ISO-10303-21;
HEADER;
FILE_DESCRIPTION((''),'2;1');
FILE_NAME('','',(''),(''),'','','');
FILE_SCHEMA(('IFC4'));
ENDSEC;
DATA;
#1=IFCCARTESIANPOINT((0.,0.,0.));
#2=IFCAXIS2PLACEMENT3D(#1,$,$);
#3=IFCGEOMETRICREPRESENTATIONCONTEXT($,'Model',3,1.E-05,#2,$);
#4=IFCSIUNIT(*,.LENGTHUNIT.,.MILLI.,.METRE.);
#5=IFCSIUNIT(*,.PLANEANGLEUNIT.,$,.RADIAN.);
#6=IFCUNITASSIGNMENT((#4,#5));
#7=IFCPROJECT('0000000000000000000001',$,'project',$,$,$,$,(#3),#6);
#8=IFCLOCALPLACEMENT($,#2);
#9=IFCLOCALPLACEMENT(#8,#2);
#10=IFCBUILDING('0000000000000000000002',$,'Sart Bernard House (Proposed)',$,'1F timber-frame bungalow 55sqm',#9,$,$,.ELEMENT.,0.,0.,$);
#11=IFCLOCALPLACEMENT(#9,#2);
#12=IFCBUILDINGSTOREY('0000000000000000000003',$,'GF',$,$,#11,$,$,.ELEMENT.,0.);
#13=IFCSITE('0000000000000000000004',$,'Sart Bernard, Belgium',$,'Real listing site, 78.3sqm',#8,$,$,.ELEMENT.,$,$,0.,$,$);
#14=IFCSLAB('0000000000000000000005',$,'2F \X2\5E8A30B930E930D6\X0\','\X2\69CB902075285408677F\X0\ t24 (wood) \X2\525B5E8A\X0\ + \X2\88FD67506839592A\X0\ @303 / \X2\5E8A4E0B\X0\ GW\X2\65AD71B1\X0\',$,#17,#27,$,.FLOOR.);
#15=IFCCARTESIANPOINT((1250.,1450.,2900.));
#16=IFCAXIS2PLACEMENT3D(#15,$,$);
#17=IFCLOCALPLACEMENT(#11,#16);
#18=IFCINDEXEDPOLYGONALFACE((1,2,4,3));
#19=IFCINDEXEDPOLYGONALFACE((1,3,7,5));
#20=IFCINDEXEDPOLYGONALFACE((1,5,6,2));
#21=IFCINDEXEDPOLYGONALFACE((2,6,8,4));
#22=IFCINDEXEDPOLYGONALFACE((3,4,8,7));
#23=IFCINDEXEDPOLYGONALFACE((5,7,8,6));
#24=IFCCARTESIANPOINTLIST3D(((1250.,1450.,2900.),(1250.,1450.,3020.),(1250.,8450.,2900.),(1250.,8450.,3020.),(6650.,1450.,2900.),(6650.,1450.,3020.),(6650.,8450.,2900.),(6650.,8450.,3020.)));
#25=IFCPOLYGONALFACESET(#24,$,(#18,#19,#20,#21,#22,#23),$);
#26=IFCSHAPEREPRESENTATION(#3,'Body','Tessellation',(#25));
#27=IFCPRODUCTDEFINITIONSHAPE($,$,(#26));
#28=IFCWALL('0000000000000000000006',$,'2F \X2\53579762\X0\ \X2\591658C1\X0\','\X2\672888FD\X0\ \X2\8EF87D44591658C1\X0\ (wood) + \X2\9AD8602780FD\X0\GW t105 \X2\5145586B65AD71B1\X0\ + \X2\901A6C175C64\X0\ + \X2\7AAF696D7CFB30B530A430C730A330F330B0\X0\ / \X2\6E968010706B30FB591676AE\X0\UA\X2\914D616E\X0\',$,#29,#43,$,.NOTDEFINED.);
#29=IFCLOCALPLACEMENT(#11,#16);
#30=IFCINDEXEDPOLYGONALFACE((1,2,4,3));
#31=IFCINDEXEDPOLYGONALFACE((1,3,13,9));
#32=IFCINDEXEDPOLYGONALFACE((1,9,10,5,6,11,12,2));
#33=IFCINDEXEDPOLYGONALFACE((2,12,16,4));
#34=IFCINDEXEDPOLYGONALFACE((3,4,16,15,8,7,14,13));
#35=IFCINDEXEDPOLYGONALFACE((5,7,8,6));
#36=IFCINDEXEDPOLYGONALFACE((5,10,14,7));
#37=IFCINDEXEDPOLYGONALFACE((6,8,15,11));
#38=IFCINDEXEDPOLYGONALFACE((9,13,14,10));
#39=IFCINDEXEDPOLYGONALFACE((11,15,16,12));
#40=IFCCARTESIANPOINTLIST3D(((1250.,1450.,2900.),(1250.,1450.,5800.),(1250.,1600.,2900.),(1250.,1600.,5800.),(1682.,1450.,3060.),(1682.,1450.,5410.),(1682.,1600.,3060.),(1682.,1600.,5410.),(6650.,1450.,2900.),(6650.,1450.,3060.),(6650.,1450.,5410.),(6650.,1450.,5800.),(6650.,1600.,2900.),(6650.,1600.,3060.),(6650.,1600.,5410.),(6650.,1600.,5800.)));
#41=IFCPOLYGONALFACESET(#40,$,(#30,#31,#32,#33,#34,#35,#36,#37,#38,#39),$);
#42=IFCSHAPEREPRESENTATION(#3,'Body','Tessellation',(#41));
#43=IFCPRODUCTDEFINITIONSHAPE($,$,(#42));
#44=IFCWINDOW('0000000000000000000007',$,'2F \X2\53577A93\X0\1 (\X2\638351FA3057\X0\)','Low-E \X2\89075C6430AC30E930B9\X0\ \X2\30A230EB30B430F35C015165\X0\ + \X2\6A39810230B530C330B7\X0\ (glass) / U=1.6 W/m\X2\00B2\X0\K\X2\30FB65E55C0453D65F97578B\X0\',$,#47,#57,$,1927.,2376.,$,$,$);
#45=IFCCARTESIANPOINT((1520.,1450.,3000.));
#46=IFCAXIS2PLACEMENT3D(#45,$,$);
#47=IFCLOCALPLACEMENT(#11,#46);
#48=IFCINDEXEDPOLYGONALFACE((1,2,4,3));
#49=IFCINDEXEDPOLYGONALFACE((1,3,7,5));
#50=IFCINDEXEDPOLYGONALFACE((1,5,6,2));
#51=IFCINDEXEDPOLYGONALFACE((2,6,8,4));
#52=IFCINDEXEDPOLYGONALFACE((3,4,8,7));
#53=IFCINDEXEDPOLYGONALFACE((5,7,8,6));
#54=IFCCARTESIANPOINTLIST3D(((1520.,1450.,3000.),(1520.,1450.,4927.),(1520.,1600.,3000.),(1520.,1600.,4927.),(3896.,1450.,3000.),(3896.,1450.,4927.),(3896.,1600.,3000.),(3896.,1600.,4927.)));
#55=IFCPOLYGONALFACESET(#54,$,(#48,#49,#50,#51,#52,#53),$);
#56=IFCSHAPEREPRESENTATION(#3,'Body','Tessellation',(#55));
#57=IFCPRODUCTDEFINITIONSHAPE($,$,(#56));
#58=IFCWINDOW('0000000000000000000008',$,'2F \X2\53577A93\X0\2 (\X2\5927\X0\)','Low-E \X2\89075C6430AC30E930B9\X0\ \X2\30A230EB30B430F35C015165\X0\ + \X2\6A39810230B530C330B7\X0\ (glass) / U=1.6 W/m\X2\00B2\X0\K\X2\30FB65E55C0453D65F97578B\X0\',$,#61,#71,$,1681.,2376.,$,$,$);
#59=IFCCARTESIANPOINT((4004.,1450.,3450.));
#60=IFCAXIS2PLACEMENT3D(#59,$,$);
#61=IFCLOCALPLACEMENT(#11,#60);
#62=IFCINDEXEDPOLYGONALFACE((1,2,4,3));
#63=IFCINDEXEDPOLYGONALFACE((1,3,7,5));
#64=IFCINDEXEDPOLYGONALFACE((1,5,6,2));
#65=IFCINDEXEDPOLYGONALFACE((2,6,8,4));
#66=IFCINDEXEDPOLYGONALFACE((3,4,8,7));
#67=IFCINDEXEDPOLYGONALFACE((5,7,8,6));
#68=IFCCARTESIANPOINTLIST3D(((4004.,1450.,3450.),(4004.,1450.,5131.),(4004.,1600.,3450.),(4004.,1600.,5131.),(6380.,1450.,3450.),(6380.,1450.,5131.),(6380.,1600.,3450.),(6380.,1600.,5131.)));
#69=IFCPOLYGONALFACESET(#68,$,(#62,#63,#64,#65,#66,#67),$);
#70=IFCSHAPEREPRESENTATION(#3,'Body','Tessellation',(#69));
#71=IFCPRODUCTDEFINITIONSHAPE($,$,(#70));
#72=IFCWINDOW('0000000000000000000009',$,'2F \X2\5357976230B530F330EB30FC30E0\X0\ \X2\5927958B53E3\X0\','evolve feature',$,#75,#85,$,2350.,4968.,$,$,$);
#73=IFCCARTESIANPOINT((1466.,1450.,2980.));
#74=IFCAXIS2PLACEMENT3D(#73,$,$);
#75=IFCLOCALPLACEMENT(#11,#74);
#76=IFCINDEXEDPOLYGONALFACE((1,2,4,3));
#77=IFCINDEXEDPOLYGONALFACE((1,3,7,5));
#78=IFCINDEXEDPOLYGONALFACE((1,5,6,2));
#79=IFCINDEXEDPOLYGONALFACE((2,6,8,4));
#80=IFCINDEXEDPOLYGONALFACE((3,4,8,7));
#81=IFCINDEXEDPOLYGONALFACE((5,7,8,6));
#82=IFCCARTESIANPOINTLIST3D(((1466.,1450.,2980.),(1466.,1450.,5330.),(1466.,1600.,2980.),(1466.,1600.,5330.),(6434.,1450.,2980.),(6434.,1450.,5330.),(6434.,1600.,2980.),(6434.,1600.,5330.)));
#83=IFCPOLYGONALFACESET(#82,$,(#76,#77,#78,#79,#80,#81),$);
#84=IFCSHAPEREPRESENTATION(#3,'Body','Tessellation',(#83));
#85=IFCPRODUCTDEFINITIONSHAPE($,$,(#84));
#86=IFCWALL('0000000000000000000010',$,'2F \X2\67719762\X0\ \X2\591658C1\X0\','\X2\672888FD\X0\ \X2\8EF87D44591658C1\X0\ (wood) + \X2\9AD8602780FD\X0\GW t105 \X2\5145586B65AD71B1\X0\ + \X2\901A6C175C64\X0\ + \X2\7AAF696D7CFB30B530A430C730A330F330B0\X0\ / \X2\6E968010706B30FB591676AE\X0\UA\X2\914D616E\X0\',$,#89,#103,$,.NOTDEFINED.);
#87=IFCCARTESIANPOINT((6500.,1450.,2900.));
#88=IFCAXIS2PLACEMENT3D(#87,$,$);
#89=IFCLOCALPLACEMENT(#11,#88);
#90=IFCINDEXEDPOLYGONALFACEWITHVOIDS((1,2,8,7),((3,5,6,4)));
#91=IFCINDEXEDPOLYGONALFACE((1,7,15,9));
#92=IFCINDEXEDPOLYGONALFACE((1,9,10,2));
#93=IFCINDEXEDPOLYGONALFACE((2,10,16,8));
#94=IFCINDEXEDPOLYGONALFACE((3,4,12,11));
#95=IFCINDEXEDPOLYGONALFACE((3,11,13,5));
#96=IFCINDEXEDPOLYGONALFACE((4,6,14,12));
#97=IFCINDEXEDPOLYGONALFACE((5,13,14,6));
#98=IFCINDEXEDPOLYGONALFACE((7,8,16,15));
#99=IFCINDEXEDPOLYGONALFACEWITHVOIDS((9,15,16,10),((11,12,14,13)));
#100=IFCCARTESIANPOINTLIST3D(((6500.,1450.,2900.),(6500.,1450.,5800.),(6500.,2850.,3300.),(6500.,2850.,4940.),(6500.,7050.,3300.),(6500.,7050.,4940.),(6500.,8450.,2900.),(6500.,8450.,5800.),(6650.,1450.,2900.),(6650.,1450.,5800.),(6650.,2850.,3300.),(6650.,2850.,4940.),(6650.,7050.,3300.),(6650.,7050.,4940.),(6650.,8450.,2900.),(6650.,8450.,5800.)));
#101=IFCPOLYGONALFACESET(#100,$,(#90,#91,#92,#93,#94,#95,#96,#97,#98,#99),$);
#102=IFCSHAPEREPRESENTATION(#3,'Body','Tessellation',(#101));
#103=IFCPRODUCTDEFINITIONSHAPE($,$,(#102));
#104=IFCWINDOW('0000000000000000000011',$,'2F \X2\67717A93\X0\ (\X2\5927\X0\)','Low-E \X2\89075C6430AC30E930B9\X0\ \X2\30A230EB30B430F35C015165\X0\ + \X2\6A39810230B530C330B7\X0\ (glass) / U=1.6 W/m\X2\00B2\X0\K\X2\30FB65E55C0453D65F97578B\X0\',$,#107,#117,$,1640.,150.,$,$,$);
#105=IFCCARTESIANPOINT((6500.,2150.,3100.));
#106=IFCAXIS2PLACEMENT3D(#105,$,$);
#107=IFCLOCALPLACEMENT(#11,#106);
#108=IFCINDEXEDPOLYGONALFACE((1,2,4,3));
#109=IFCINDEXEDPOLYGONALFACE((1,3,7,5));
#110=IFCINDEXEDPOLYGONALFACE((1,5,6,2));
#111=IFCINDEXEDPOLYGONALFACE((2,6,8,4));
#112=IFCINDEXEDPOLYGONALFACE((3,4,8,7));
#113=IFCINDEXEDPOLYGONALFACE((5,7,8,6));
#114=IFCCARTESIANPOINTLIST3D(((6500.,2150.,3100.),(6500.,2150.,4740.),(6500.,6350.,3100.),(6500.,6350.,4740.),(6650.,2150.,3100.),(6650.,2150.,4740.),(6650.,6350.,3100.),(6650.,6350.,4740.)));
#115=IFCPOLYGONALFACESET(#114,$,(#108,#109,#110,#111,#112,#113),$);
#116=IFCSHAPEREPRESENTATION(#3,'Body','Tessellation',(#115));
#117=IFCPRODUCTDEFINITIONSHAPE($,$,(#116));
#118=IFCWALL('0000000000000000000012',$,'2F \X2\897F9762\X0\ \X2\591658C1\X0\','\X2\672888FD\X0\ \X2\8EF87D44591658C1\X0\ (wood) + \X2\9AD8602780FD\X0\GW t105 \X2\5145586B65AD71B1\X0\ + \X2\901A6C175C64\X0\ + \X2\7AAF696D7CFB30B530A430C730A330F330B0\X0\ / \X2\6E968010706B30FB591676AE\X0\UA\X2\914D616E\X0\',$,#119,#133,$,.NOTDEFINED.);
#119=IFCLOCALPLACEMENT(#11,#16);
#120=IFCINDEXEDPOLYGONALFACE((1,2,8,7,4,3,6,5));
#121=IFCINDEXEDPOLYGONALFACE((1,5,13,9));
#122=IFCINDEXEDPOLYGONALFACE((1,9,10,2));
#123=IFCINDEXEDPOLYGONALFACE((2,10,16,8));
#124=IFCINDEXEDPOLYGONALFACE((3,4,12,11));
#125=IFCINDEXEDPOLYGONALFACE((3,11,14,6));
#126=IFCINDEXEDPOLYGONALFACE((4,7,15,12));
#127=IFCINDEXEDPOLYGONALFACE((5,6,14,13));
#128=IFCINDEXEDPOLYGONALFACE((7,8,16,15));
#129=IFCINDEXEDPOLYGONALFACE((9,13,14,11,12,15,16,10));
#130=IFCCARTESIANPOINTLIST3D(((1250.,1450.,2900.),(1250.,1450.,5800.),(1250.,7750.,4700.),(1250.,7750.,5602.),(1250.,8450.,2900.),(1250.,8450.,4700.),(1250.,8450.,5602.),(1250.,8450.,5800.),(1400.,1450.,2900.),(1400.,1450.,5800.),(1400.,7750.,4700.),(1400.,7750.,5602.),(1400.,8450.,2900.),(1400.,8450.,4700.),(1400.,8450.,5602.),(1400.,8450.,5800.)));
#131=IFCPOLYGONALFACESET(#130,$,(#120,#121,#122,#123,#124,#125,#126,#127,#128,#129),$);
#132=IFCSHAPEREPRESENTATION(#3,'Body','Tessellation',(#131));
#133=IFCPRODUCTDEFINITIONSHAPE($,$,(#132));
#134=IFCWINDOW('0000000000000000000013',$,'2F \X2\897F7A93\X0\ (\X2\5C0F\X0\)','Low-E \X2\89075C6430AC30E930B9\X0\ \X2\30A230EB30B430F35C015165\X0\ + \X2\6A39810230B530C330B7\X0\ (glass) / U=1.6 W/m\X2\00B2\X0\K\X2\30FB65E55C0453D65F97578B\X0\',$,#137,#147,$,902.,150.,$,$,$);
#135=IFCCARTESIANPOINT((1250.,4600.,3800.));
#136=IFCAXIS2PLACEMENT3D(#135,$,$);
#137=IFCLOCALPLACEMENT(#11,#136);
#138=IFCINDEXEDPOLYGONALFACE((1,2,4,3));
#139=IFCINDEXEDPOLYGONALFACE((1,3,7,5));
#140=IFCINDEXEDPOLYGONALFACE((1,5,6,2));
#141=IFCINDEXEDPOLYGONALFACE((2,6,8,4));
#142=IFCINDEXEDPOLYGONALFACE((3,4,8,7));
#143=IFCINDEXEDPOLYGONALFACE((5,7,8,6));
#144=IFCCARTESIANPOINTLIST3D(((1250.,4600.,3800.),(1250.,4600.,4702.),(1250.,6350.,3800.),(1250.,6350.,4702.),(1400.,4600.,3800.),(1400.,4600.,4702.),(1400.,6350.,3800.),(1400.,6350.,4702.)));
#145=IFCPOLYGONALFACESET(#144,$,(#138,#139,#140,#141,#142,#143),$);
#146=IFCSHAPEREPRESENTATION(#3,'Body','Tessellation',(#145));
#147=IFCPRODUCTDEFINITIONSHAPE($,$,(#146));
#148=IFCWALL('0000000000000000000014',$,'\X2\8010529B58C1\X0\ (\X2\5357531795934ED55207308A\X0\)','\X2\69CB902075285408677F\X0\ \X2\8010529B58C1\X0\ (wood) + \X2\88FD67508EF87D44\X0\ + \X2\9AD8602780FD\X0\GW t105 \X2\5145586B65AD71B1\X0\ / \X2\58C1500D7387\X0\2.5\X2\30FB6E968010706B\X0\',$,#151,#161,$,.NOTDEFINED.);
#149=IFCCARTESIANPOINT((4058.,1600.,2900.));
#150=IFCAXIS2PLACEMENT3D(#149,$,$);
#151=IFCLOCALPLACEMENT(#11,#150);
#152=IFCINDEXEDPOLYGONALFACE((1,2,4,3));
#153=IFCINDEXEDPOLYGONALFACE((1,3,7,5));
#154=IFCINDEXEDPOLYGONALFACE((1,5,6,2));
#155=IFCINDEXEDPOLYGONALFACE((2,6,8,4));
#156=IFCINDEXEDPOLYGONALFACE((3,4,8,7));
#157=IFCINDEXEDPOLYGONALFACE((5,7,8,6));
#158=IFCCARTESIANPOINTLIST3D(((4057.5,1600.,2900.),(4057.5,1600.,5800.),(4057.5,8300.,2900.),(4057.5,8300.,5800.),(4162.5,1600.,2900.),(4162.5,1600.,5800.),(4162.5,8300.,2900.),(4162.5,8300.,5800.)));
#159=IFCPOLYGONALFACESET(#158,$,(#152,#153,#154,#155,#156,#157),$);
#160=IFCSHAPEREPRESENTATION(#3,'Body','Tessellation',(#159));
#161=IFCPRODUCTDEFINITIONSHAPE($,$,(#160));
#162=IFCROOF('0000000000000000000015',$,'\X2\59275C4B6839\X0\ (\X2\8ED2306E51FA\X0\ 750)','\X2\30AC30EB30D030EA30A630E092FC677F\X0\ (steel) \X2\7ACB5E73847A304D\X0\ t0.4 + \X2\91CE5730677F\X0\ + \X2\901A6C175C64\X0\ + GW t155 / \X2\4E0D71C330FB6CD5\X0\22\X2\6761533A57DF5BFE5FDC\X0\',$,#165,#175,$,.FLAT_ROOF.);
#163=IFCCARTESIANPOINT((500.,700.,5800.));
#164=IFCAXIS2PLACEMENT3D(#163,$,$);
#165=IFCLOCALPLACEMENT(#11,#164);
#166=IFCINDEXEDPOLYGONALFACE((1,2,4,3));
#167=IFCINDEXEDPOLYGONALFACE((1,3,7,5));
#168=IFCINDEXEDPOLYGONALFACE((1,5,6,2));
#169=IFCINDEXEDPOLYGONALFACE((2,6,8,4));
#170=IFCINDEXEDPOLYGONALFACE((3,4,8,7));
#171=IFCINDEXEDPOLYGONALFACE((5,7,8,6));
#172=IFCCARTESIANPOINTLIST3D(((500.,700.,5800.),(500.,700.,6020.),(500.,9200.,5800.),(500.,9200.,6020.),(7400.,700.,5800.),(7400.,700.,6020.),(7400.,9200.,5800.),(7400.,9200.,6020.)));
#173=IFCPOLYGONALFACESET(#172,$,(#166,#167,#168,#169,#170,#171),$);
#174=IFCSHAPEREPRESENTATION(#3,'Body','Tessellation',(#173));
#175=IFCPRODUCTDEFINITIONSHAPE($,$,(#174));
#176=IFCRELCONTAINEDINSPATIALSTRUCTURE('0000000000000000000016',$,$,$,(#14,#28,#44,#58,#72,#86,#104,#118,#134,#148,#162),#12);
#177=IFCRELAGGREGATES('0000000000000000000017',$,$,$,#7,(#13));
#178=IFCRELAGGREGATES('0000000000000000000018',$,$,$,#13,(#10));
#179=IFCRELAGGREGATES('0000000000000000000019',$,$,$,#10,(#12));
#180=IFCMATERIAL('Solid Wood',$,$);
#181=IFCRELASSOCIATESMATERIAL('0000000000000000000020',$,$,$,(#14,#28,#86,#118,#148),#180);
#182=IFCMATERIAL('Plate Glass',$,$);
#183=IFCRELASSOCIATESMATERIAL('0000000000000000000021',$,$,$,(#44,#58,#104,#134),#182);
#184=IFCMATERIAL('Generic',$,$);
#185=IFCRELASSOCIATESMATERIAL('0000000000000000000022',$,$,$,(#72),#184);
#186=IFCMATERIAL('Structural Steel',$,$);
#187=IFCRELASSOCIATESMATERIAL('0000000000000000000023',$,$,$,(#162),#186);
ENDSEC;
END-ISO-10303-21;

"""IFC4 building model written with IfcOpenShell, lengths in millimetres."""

from ifc_helpers import new_model, si_unit, frame, frame_2d, origin, place, context, project, spatial, rectangle, extrude, material, element, fill, save


model = new_model("IFC4")

# Units and contexts
model_context = context("Model", 3, precision=1e-05, world=origin())
ifc_project = project(units=[si_unit("LENGTHUNIT", "METRE", prefix="MILLI"), si_unit("PLANEANGLEUNIT", "RADIAN")], contexts=[model_context])

# Site, building, storey
site_placement = place(None, origin())
site = spatial("IfcSite", under=ifc_project, at=site_placement, Name="Sart Bernard, Belgium", ObjectType="Real listing site, 78.3sqm", CompositionType="ELEMENT", RefElevation=0.0)
building_placement = place(site_placement, origin())
building = spatial("IfcBuilding", under=site, at=building_placement, Name="Sart Bernard House (Proposed)", ObjectType="1F timber-frame bungalow 55sqm", CompositionType="ELEMENT", ElevationOfRefHeight=0.0, ElevationOfTerrain=0.0)
storey_placement = place(building_placement, origin())
storey = spatial("IfcBuildingStorey", under=building, at=storey_placement, Name="GF", CompositionType="ELEMENT", Elevation=0.0)

# Slab
ifc_material_1 = material(Name="Solid Wood")
slab_placement = place(storey_placement, frame((1250.0, 1450.0, 2900.0)))
element("IfcSlab", 1, at=slab_placement, inside=storey, material=ifc_material_1, Name="2F 床スラブ", Description="構造用合板 t24 (wood) 剛床 + 製材根太 @303 / 床下 GW断熱", PredefinedType="FLOOR", context=model_context, shape_type="SweptSolid", body=[
    extrude(rectangle(XDim=5400.0, YDim=7000.0, at=frame_2d((2700.0, 3500.0))), frame((1250.0, 1450.0, 2900.0)), (0.0, 0.0, 1.0), 120.0),
])

# Wall, openings, windows
wall_1_placement = place(storey_placement, frame((1250.0, 1450.0, 2900.0)))
wall_1 = element("IfcWall", 2, at=wall_1_placement, inside=storey, material=ifc_material_1, Name="2F 南面 外壁", Description="木製 軸組外壁 (wood) + 高性能GW t105 充填断熱 + 通気層 + 窯業系サイディング / 準耐火・外皮UA配慮", PredefinedType="NOTDEFINED", context=model_context, shape_type="SweptSolid", body=[
    extrude(rectangle(XDim=5400.0, YDim=150.0, at=frame_2d((2700.0, 75.0))), frame((1250.0, 1450.0, 2900.0)), (0.0, 0.0, 1.0), 2900.0),
])
opening_1_placement = place(storey_placement, frame((1520.0, 1450.0, 3000.0)))
opening_1 = element("IfcOpeningElement", 3, at=opening_1_placement, cuts=wall_1, PredefinedType="NOTDEFINED", context=model_context, shape_type="SweptSolid", body=[
    extrude(rectangle(XDim=2376.0, YDim=150.0, at=frame_2d((1188.0, 75.0))), frame((1520.0, 1450.0, 3000.0)), (0.0, 0.0, 1.0), 1927.0),
])
opening_2_placement = place(storey_placement, frame((4004.0, 1450.0, 3450.0)))
opening_2 = element("IfcOpeningElement", 4, at=opening_2_placement, cuts=wall_1, PredefinedType="NOTDEFINED", context=model_context, shape_type="SweptSolid", body=[
    extrude(rectangle(XDim=2376.0, YDim=150.0, at=frame_2d((1188.0, 75.0))), frame((4004.0, 1450.0, 3450.0)), (0.0, 0.0, 1.0), 1681.0),
])
opening_3_placement = place(storey_placement, frame((1466.0, 1450.0, 2980.0)))
opening_3 = element("IfcOpeningElement", 5, at=opening_3_placement, cuts=wall_1, PredefinedType="NOTDEFINED", context=model_context, shape_type="SweptSolid", body=[
    extrude(rectangle(XDim=4968.0, YDim=150.0, at=frame_2d((2484.0, 75.0))), frame((1466.0, 1450.0, 2980.0)), (0.0, 0.0, 1.0), 2350.0),
])
ifc_material_2 = material(Name="Plate Glass")
window_1_placement = place(storey_placement, frame((1520.0, 1450.0, 3000.0)))
window_1 = element("IfcWindow", 6, at=window_1_placement, inside=storey, material=ifc_material_2, Name="2F 南窓1 (掃出し)", Description="Low-E 複層ガラス アルゴン封入 + 樹脂サッシ (glass) / U=1.6 W/m²K・日射取得型", OverallHeight=1927.0, OverallWidth=2376.0, context=model_context, shape_type="SweptSolid", body=[
    extrude(rectangle(XDim=2376.0, YDim=150.0, at=frame_2d((1188.0, 75.0))), frame((1520.0, 1450.0, 3000.0)), (0.0, 0.0, 1.0), 1927.0),
])
fill(opening_1, window_1)
window_2_placement = place(storey_placement, frame((4004.0, 1450.0, 3450.0)))
window_2 = element("IfcWindow", 7, at=window_2_placement, inside=storey, material=ifc_material_2, Name="2F 南窓2 (大)", Description="Low-E 複層ガラス アルゴン封入 + 樹脂サッシ (glass) / U=1.6 W/m²K・日射取得型", OverallHeight=1681.0, OverallWidth=2376.0, context=model_context, shape_type="SweptSolid", body=[
    extrude(rectangle(XDim=2376.0, YDim=150.0, at=frame_2d((1188.0, 75.0))), frame((4004.0, 1450.0, 3450.0)), (0.0, 0.0, 1.0), 1681.0),
])
fill(opening_2, window_2)
ifc_material_3 = material(Name="Generic")
window_3_placement = place(storey_placement, frame((1466.0, 1450.0, 2980.0)))
window_3 = element("IfcWindow", 8, at=window_3_placement, inside=storey, material=ifc_material_3, Name="2F 南面サンルーム 大開口", Description="evolve feature", OverallHeight=2350.0, OverallWidth=4968.0, context=model_context, shape_type="SweptSolid", body=[
    extrude(rectangle(XDim=4968.0, YDim=150.0, at=frame_2d((2484.0, 75.0))), frame((1466.0, 1450.0, 2980.0)), (0.0, 0.0, 1.0), 2350.0),
])
fill(opening_3, window_3)

# Walls, openings, windows
wall_2_placement = place(storey_placement, frame((6500.0, 1450.0, 2900.0)))
wall_2 = element("IfcWall", 9, at=wall_2_placement, inside=storey, material=ifc_material_1, Name="2F 東面 外壁", Description="木製 軸組外壁 (wood) + 高性能GW t105 充填断熱 + 通気層 + 窯業系サイディング / 準耐火・外皮UA配慮", PredefinedType="NOTDEFINED", context=model_context, shape_type="SweptSolid", body=[
    extrude(rectangle(XDim=150.0, YDim=7000.0, at=frame_2d((75.0, 3500.0))), frame((6500.0, 1450.0, 2900.0)), (0.0, 0.0, 1.0), 2900.0),
])
opening_4_placement = place(storey_placement, frame((6500.0, 2150.0, 3100.0)))
opening_4 = element("IfcOpeningElement", 10, at=opening_4_placement, cuts=wall_2, PredefinedType="NOTDEFINED", context=model_context, shape_type="SweptSolid", body=[
    extrude(rectangle(XDim=150.0, YDim=4200.0, at=frame_2d((75.0, 2100.0))), frame((6500.0, 2150.0, 3100.0)), (0.0, 0.0, 1.0), 1640.0),
])
window_4_placement = place(storey_placement, frame((6500.0, 2150.0, 3100.0)))
window_4 = element("IfcWindow", 11, at=window_4_placement, inside=storey, material=ifc_material_2, Name="2F 東窓 (大)", Description="Low-E 複層ガラス アルゴン封入 + 樹脂サッシ (glass) / U=1.6 W/m²K・日射取得型", OverallHeight=1640.0, OverallWidth=150.0, context=model_context, shape_type="SweptSolid", body=[
    extrude(rectangle(XDim=150.0, YDim=4200.0, at=frame_2d((75.0, 2100.0))), frame((6500.0, 2150.0, 3100.0)), (0.0, 0.0, 1.0), 1640.0),
])
fill(opening_4, window_4)
wall_3_placement = place(storey_placement, frame((1250.0, 1450.0, 2900.0)))
wall_3 = element("IfcWall", 12, at=wall_3_placement, inside=storey, material=ifc_material_1, Name="2F 西面 外壁", Description="木製 軸組外壁 (wood) + 高性能GW t105 充填断熱 + 通気層 + 窯業系サイディング / 準耐火・外皮UA配慮", PredefinedType="NOTDEFINED", context=model_context, shape_type="SweptSolid", body=[
    extrude(rectangle(XDim=150.0, YDim=7000.0, at=frame_2d((75.0, 3500.0))), frame((1250.0, 1450.0, 2900.0)), (0.0, 0.0, 1.0), 2900.0),
])
opening_5_placement = place(storey_placement, frame((1250.0, 4600.0, 3800.0)))
opening_5 = element("IfcOpeningElement", 13, at=opening_5_placement, cuts=wall_3, PredefinedType="NOTDEFINED", context=model_context, shape_type="SweptSolid", body=[
    extrude(rectangle(XDim=150.0, YDim=1750.0, at=frame_2d((75.0, 875.0))), frame((1250.0, 4600.0, 3800.0)), (0.0, 0.0, 1.0), 902.0),
])
window_5_placement = place(storey_placement, frame((1250.0, 4600.0, 3800.0)))
window_5 = element("IfcWindow", 14, at=window_5_placement, inside=storey, material=ifc_material_2, Name="2F 西窓 (小)", Description="Low-E 複層ガラス アルゴン封入 + 樹脂サッシ (glass) / U=1.6 W/m²K・日射取得型", OverallHeight=902.0, OverallWidth=150.0, context=model_context, shape_type="SweptSolid", body=[
    extrude(rectangle(XDim=150.0, YDim=1750.0, at=frame_2d((75.0, 875.0))), frame((1250.0, 4600.0, 3800.0)), (0.0, 0.0, 1.0), 902.0),
])
fill(opening_5, window_5)

# Wall
wall_4_placement = place(storey_placement, frame((4058.0, 1600.0, 2900.0)))
element("IfcWall", 15, at=wall_4_placement, inside=storey, material=ifc_material_1, Name="耐力壁 (南北間仕切り)", Description="構造用合板 耐力壁 (wood) + 製材軸組 + 高性能GW t105 充填断熱 / 壁倍率2.5・準耐火", PredefinedType="NOTDEFINED", context=model_context, shape_type="SweptSolid", body=[
    extrude(rectangle(XDim=105.0, YDim=6700.0, at=frame_2d((52.0, 3350.0))), frame((4058.0, 1600.0, 2900.0)), (0.0, 0.0, 1.0), 2900.0),
])

# Roof
ifc_material_4 = material(Name="Structural Steel")
roof_placement = place(storey_placement, frame((500.0, 700.0, 5800.0)))
element("IfcRoof", 16, at=roof_placement, inside=storey, material=ifc_material_4, Name="大屋根 (軒の出 750)", Description="ガルバリウム鋼板 (steel) 立平葺き t0.4 + 野地板 + 通気層 + GW t155 / 不燃・法22条区域対応", PredefinedType="FLAT_ROOF", context=model_context, shape_type="SweptSolid", body=[
    extrude(rectangle(XDim=6900.0, YDim=8500.0, at=frame_2d((3450.0, 4250.0))), frame((500.0, 700.0, 5800.0)), (0.0, 0.0, 1.0), 220.0),
])

save(model, "model.ifc")
